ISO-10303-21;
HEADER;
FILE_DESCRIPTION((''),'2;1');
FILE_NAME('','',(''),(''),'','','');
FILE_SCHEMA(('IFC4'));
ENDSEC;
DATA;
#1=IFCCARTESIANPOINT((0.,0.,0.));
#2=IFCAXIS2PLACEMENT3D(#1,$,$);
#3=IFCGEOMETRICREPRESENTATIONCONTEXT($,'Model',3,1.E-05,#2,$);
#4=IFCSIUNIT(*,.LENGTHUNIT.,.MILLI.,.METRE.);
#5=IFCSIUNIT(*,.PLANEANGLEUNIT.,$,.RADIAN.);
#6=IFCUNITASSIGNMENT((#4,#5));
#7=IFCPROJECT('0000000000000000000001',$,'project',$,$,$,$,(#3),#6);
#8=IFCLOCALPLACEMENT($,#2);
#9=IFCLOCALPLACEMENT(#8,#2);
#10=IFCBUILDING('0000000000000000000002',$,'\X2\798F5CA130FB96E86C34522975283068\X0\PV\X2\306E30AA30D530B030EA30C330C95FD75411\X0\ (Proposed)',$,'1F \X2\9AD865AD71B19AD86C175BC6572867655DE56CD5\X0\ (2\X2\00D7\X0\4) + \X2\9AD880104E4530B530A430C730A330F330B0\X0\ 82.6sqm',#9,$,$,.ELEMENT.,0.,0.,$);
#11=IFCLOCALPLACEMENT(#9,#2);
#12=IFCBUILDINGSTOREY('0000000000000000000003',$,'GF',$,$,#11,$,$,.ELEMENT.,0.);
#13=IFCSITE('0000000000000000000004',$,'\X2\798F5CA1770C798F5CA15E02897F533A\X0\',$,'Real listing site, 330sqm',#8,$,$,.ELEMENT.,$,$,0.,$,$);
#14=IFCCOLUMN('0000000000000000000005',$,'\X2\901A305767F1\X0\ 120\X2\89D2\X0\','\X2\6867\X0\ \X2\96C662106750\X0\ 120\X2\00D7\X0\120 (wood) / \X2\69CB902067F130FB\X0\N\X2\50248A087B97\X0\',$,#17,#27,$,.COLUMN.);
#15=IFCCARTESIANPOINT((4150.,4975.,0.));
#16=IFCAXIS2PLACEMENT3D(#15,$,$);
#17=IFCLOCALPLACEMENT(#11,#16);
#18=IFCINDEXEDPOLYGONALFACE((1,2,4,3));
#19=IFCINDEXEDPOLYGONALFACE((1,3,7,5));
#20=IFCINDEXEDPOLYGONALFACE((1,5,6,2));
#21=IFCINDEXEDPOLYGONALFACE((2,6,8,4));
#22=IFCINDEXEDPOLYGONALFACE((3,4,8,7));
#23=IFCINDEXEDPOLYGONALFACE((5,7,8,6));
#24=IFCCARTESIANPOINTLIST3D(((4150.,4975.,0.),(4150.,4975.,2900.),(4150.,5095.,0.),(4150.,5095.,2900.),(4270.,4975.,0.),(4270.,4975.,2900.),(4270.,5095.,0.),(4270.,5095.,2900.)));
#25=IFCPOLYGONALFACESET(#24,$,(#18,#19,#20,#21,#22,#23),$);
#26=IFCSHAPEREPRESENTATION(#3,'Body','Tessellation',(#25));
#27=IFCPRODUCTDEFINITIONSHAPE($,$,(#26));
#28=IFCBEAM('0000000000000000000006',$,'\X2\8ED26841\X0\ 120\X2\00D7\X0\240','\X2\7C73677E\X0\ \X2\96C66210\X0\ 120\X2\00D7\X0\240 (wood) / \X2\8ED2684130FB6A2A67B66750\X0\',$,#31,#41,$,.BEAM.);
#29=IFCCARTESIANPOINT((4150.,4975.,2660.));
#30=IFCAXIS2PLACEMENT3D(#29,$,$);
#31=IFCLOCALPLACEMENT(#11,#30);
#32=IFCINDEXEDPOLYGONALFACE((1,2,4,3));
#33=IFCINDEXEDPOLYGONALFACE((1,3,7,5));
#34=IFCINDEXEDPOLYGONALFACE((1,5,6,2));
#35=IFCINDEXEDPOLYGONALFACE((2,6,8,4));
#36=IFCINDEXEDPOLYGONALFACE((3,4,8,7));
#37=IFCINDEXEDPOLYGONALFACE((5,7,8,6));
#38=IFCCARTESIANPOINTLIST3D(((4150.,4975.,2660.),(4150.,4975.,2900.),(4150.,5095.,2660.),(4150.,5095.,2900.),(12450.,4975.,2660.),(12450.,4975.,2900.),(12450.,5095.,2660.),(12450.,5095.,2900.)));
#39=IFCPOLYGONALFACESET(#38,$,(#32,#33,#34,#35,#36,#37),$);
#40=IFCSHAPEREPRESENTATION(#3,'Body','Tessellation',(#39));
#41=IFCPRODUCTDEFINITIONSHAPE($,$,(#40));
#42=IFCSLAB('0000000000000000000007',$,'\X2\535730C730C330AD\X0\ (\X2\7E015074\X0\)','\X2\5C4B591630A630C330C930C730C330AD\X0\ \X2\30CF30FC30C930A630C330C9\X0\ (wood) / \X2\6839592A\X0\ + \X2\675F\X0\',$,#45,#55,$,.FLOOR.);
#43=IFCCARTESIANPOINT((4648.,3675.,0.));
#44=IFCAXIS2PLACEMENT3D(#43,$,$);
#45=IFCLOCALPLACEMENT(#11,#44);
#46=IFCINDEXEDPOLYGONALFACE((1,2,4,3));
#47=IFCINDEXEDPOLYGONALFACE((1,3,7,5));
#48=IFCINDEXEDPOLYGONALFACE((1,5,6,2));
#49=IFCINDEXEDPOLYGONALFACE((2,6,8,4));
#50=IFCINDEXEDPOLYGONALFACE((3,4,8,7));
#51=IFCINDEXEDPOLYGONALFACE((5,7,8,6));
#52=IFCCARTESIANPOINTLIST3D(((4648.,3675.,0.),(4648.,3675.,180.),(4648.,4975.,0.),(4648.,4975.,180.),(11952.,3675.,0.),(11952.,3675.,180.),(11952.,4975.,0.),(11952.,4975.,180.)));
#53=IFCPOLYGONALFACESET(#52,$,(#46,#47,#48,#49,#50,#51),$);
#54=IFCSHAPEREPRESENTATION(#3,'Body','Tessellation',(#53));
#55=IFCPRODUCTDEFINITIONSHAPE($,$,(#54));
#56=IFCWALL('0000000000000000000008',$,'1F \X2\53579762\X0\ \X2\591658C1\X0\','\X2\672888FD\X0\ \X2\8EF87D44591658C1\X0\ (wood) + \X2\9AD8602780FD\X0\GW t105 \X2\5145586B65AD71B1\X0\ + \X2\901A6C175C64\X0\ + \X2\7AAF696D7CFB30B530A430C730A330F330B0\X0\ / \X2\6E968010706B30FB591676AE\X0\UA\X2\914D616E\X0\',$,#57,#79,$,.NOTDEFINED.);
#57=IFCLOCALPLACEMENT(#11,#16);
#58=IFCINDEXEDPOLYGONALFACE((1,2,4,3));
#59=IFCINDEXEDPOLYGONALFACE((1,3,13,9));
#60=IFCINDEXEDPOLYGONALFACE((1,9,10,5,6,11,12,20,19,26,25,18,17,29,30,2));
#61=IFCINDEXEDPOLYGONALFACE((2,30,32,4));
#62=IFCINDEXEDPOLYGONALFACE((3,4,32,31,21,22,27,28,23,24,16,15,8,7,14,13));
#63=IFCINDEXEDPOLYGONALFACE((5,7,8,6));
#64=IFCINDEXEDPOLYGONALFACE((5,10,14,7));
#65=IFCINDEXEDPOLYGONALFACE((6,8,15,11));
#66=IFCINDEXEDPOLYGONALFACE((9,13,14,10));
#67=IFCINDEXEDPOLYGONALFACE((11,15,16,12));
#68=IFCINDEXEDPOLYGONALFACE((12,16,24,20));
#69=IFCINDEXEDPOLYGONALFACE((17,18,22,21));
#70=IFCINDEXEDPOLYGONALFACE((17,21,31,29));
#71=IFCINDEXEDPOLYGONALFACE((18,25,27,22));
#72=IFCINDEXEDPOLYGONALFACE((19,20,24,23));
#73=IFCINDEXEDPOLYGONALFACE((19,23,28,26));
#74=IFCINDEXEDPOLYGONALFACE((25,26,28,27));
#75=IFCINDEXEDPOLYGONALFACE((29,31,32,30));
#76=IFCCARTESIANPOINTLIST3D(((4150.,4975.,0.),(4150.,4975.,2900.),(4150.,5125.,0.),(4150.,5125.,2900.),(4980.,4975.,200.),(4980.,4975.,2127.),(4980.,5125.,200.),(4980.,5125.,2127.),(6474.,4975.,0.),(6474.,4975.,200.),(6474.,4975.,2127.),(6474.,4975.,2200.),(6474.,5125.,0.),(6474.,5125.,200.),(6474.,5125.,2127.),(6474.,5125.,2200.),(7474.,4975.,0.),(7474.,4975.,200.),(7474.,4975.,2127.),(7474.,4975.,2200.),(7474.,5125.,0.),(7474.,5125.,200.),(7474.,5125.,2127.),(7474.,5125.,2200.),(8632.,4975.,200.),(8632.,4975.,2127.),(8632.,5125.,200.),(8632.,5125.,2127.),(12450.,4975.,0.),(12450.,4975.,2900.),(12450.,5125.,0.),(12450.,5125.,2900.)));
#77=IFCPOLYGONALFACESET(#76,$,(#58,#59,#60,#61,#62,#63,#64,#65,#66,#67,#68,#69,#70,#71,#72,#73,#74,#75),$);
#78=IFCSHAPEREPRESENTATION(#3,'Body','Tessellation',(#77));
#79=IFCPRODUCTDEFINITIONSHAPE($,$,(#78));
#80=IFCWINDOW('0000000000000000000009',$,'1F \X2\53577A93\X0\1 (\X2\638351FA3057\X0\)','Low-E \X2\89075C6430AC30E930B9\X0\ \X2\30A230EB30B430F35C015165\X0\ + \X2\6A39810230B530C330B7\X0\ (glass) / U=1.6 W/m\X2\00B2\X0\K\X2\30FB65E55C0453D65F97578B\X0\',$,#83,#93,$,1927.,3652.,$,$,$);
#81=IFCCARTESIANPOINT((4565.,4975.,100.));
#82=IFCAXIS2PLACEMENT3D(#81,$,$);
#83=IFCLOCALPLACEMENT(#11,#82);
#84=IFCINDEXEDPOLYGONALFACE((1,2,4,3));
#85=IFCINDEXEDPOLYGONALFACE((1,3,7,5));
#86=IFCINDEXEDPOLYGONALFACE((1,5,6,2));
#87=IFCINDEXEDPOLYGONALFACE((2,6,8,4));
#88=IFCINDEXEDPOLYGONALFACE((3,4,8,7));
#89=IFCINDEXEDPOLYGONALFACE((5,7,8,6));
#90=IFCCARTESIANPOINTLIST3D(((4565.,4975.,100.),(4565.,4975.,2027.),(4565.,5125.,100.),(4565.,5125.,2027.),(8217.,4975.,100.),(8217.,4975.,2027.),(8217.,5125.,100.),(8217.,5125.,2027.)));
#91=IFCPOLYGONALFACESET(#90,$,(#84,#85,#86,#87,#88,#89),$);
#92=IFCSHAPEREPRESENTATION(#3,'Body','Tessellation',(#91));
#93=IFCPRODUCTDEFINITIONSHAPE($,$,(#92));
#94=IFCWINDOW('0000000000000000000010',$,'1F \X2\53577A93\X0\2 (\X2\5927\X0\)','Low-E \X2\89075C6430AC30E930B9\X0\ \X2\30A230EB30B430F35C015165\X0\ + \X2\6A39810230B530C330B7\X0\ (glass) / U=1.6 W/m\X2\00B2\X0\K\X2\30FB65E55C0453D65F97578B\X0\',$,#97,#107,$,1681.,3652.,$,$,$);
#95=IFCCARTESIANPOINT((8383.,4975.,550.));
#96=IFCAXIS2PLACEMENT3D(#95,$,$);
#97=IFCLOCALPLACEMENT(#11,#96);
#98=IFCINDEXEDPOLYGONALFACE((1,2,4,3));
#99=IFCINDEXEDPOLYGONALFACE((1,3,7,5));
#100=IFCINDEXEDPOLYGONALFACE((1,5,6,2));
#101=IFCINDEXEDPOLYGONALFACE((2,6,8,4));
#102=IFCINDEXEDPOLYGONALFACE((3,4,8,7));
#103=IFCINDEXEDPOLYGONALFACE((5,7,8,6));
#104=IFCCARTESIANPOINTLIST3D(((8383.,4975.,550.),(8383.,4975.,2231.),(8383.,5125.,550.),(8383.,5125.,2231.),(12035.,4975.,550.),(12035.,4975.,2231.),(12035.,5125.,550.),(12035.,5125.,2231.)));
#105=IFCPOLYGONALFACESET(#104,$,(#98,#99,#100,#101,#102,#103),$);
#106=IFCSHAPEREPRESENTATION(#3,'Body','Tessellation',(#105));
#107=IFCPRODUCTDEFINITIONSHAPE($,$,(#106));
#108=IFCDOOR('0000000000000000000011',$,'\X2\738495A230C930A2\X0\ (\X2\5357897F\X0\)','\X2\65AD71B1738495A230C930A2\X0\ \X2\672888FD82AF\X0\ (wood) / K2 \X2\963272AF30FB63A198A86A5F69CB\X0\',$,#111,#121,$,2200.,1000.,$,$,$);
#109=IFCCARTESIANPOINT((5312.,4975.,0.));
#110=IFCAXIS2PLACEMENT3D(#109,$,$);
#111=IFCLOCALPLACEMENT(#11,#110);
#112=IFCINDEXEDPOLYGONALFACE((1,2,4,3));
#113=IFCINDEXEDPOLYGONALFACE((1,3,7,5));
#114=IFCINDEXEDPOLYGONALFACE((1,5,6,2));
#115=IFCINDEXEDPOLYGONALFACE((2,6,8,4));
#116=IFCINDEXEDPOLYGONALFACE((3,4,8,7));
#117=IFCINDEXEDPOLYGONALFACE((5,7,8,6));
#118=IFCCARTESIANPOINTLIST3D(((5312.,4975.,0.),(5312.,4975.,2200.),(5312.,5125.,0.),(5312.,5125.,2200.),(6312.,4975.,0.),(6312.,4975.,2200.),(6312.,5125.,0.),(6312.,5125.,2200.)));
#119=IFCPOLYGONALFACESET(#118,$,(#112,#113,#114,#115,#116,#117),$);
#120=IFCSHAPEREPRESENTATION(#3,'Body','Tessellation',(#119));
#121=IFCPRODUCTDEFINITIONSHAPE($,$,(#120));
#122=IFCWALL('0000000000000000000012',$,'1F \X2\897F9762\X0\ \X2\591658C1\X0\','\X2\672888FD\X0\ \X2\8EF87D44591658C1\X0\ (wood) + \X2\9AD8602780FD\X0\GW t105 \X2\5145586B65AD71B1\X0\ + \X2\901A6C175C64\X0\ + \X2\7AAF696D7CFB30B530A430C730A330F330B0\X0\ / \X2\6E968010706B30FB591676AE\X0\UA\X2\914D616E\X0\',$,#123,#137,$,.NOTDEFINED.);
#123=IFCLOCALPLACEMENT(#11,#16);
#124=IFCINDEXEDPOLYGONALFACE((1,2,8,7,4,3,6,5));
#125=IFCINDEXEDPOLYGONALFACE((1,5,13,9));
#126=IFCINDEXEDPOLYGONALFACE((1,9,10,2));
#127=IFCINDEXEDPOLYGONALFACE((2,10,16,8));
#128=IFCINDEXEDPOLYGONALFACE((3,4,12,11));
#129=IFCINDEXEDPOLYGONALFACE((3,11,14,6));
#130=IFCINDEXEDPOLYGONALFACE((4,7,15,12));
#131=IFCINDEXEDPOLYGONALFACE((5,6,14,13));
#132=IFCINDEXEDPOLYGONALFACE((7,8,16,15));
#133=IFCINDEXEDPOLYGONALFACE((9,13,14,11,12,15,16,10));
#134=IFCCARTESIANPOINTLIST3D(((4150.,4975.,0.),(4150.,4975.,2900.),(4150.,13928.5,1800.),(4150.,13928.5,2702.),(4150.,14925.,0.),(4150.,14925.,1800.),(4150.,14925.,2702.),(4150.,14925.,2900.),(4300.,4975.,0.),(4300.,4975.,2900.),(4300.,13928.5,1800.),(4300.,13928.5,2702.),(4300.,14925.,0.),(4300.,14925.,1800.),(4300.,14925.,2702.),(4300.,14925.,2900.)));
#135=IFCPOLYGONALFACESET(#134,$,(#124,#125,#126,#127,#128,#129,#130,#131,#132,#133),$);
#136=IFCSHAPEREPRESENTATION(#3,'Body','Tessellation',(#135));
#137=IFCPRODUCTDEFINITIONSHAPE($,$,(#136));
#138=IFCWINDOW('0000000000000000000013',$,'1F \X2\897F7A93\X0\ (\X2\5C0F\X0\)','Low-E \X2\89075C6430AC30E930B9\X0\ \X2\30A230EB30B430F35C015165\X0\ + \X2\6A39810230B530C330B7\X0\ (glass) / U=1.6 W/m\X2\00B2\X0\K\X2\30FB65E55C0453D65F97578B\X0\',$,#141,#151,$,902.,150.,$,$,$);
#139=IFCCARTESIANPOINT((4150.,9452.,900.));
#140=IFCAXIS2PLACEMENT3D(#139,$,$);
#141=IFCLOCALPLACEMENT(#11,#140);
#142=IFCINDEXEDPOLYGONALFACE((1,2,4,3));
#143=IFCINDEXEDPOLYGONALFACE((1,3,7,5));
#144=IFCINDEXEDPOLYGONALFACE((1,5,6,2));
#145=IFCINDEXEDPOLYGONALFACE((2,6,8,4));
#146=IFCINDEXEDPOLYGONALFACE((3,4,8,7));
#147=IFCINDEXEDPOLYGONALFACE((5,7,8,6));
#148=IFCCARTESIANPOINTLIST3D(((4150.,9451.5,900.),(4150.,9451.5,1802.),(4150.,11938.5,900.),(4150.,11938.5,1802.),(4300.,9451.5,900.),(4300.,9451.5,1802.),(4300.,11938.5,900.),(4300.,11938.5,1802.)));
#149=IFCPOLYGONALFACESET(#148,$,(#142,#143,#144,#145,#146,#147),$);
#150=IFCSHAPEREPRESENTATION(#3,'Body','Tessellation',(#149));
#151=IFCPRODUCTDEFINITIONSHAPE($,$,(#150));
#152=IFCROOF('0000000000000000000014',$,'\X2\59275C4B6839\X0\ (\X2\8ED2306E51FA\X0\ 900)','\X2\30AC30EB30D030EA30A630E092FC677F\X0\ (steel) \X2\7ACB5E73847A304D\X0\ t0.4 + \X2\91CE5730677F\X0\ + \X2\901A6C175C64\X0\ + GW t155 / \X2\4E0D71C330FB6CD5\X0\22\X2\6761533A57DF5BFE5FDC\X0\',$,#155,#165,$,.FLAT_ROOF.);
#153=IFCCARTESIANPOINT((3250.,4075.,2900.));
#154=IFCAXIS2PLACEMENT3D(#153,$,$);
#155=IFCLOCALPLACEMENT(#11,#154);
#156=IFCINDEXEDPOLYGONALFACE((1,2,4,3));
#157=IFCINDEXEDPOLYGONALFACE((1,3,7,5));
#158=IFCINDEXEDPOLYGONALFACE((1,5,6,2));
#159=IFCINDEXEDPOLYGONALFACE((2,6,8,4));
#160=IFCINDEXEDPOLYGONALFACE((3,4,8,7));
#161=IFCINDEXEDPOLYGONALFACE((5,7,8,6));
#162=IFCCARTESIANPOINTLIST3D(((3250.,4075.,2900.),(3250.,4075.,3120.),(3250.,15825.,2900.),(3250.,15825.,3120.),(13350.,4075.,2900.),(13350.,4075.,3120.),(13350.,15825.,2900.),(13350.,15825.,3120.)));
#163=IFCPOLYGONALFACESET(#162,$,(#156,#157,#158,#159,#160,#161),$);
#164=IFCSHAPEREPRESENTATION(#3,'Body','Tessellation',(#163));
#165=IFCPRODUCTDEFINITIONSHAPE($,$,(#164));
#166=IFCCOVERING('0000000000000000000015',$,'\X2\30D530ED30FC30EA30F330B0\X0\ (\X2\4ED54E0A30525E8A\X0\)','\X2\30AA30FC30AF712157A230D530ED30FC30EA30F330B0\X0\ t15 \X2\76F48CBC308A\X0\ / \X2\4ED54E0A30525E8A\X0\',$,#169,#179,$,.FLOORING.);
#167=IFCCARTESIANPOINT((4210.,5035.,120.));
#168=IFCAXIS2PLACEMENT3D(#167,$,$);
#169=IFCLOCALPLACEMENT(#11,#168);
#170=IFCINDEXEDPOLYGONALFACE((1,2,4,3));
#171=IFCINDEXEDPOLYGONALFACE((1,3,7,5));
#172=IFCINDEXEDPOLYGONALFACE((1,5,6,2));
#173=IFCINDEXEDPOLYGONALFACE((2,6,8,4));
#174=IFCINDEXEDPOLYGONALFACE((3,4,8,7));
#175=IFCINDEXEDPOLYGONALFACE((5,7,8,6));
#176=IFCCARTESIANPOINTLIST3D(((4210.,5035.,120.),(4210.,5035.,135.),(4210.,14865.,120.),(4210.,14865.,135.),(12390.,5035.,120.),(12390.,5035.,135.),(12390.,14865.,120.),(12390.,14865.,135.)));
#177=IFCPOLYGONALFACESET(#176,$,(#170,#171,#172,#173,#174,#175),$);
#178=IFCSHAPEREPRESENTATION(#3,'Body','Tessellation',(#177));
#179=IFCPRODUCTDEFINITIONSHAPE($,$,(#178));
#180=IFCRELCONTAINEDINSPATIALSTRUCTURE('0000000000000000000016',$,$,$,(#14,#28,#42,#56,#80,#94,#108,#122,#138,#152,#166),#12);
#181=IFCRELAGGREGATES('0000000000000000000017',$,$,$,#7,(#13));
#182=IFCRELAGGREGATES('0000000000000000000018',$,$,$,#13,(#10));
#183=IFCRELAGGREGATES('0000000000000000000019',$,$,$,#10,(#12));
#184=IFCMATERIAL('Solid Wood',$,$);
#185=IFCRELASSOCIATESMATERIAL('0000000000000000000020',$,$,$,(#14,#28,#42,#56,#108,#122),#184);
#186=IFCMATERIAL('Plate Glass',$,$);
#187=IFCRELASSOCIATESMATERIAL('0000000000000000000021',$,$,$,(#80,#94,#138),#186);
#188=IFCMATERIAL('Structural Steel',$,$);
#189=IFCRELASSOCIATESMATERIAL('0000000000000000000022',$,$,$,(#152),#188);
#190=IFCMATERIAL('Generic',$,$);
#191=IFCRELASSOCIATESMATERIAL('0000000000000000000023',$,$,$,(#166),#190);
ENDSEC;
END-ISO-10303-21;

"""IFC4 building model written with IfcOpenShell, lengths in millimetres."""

from ifc_helpers import new_model, si_unit, frame, frame_2d, origin, place, context, project, spatial, rectangle, extrude, material, element, fill, save


model = new_model("IFC4")

# Units and contexts
model_context = context("Model", 3, precision=1e-05, world=origin())
ifc_project = project(units=[si_unit("LENGTHUNIT", "METRE", prefix="MILLI"), si_unit("PLANEANGLEUNIT", "RADIAN")], contexts=[model_context])

# Site, building, storey
site_placement = place(None, origin())
site = spatial("IfcSite", under=ifc_project, at=site_placement, Name="福岡県福岡市西区", ObjectType="Real listing site, 330sqm", CompositionType="ELEMENT", RefElevation=0.0)
building_placement = place(site_placement, origin())
building = spatial("IfcBuilding", under=site, at=building_placement, Name="福岡・雨水利用とPVのオフグリッド志向 (Proposed)", ObjectType="1F 高断熱高気密在来工法 (2×4) + 高耐久サイディング 82.6sqm", CompositionType="ELEMENT", ElevationOfRefHeight=0.0, ElevationOfTerrain=0.0)
storey_placement = place(building_placement, origin())
storey = spatial("IfcBuildingStorey", under=building, at=storey_placement, Name="GF", CompositionType="ELEMENT", Elevation=0.0)

# Column
ifc_material_1 = material(Name="Solid Wood")
column_1_placement = place(storey_placement, frame((4150.0, 4975.0, 0.0)))
element("IfcColumn", 1, at=column_1_placement, inside=storey, material=ifc_material_1, Name="通し柱 120角", Description="桧 集成材 120×120 (wood) / 構造柱・N値計算", PredefinedType="COLUMN", context=model_context, shape_type="SweptSolid", body=[
    extrude(rectangle(XDim=120.0, YDim=120.0, at=frame_2d((60.0, 60.0))), frame((4150.0, 4975.0, 0.0)), (0.0, 0.0, 1.0), 2900.0),
])

# Beam
beam_1_placement = place(storey_placement, frame((4150.0, 4975.0, 2660.0)))
element("IfcBeam", 2, at=beam_1_placement, inside=storey, material=ifc_material_1, Name="軒桁 120×240", Description="米松 集成 120×240 (wood) / 軒桁・横架材", PredefinedType="BEAM", context=model_context, shape_type="SweptSolid", body=[
    extrude(rectangle(XDim=8300.0, YDim=120.0, at=frame_2d((4150.0, 60.0))), frame((4150.0, 4975.0, 2660.0)), (0.0, 0.0, 1.0), 240.0),
])

# Slab
slab_1_placement = place(storey_placement, frame((4648.0, 3675.0, 0.0)))
element("IfcSlab", 3, at=slab_1_placement, inside=storey, material=ifc_material_1, Name="南デッキ (縁側)", Description="屋外ウッドデッキ ハードウッド (wood) / 根太 + 束", PredefinedType="FLOOR", context=model_context, shape_type="SweptSolid", body=[
    extrude(rectangle(XDim=7304.0, YDim=1300.0, at=frame_2d((3652.0, 650.0))), frame((4648.0, 3675.0, 0.0)), (0.0, 0.0, 1.0), 180.0),
])

# Wall, openings, windows, door
wall_1_placement = place(storey_placement, frame((4150.0, 4975.0, 0.0)))
wall_1 = element("IfcWall", 4, at=wall_1_placement, inside=storey, material=ifc_material_1, Name="1F 南面 外壁", Description="木製 軸組外壁 (wood) + 高性能GW t105 充填断熱 + 通気層 + 窯業系サイディング / 準耐火・外皮UA配慮", PredefinedType="NOTDEFINED", context=model_context, shape_type="SweptSolid", body=[
    extrude(rectangle(XDim=8300.0, YDim=150.0, at=frame_2d((4150.0, 75.0))), frame((4150.0, 4975.0, 0.0)), (0.0, 0.0, 1.0), 2900.0),
])
opening_1_placement = place(storey_placement, frame((4565.0, 4975.0, 100.0)))
opening_1 = element("IfcOpeningElement", 5, at=opening_1_placement, cuts=wall_1, PredefinedType="NOTDEFINED", context=model_context, shape_type="SweptSolid", body=[
    extrude(rectangle(XDim=3652.0, YDim=150.0, at=frame_2d((1826.0, 75.0))), frame((4565.0, 4975.0, 100.0)), (0.0, 0.0, 1.0), 1927.0),
])
opening_2_placement = place(storey_placement, frame((8383.0, 4975.0, 550.0)))
opening_2 = element("IfcOpeningElement", 6, at=opening_2_placement, cuts=wall_1, PredefinedType="NOTDEFINED", context=model_context, shape_type="SweptSolid", body=[
    extrude(rectangle(XDim=3652.0, YDim=150.0, at=frame_2d((1826.0, 75.0))), frame((8383.0, 4975.0, 550.0)), (0.0, 0.0, 1.0), 1681.0),
])
opening_3_placement = place(storey_placement, frame((5312.0, 4975.0, 0.0)))
opening_3 = element("IfcOpeningElement", 7, at=opening_3_placement, cuts=wall_1, PredefinedType="NOTDEFINED", context=model_context, shape_type="SweptSolid", body=[
    extrude(rectangle(XDim=1000.0, YDim=150.0, at=frame_2d((500.0, 75.0))), frame((5312.0, 4975.0, 0.0)), (0.0, 0.0, 1.0), 2200.0),
])
ifc_material_2 = material(Name="Plate Glass")
window_1_placement = place(storey_placement, frame((4565.0, 4975.0, 100.0)))
window_1 = element("IfcWindow", 8, at=window_1_placement, inside=storey, material=ifc_material_2, Name="1F 南窓1 (掃出し)", Description="Low-E 複層ガラス アルゴン封入 + 樹脂サッシ (glass) / U=1.6 W/m²K・日射取得型", OverallHeight=1927.0, OverallWidth=3652.0, context=model_context, shape_type="SweptSolid", body=[
    extrude(rectangle(XDim=3652.0, YDim=150.0, at=frame_2d((1826.0, 75.0))), frame((4565.0, 4975.0, 100.0)), (0.0, 0.0, 1.0), 1927.0),
])
fill(opening_1, window_1)
window_2_placement = place(storey_placement, frame((8383.0, 4975.0, 550.0)))
window_2 = element("IfcWindow", 9, at=window_2_placement, inside=storey, material=ifc_material_2, Name="1F 南窓2 (大)", Description="Low-E 複層ガラス アルゴン封入 + 樹脂サッシ (glass) / U=1.6 W/m²K・日射取得型", OverallHeight=1681.0, OverallWidth=3652.0, context=model_context, shape_type="SweptSolid", body=[
    extrude(rectangle(XDim=3652.0, YDim=150.0, at=frame_2d((1826.0, 75.0))), frame((8383.0, 4975.0, 550.0)), (0.0, 0.0, 1.0), 1681.0),
])
fill(opening_2, window_2)
door_placement = place(storey_placement, frame((5312.0, 4975.0, 0.0)))
door = element("IfcDoor", 10, at=door_placement, inside=storey, material=ifc_material_1, Name="玄関ドア (南西)", Description="断熱玄関ドア 木製芯 (wood) / K2 防犯・採風機構", OverallHeight=2200.0, OverallWidth=1000.0, context=model_context, shape_type="SweptSolid", body=[
    extrude(rectangle(XDim=1000.0, YDim=150.0, at=frame_2d((500.0, 75.0))), frame((5312.0, 4975.0, 0.0)), (0.0, 0.0, 1.0), 2200.0),
])
fill(opening_3, door)

# Wall, opening, window
wall_2_placement = place(storey_placement, frame((4150.0, 4975.0, 0.0)))
wall_2 = element("IfcWall", 11, at=wall_2_placement, inside=storey, material=ifc_material_1, Name="1F 西面 外壁", Description="木製 軸組外壁 (wood) + 高性能GW t105 充填断熱 + 通気層 + 窯業系サイディング / 準耐火・外皮UA配慮", PredefinedType="NOTDEFINED", context=model_context, shape_type="SweptSolid", body=[
    extrude(rectangle(XDim=150.0, YDim=9950.0, at=frame_2d((75.0, 4975.0))), frame((4150.0, 4975.0, 0.0)), (0.0, 0.0, 1.0), 2900.0),
])
opening_4_placement = place(storey_placement, frame((4150.0, 9452.0, 900.0)))
opening_4 = element("IfcOpeningElement", 12, at=opening_4_placement, cuts=wall_2, PredefinedType="NOTDEFINED", context=model_context, shape_type="SweptSolid", body=[
    extrude(rectangle(XDim=150.0, YDim=2487.0, at=frame_2d((75.0, 1243.0))), frame((4150.0, 9452.0, 900.0)), (0.0, 0.0, 1.0), 902.0),
])
window_3_placement = place(storey_placement, frame((4150.0, 9452.0, 900.0)))
window_3 = element("IfcWindow", 13, at=window_3_placement, inside=storey, material=ifc_material_2, Name="1F 西窓 (小)", Description="Low-E 複層ガラス アルゴン封入 + 樹脂サッシ (glass) / U=1.6 W/m²K・日射取得型", OverallHeight=902.0, OverallWidth=150.0, context=model_context, shape_type="SweptSolid", body=[
    extrude(rectangle(XDim=150.0, YDim=2487.0, at=frame_2d((75.0, 1243.0))), frame((4150.0, 9452.0, 900.0)), (0.0, 0.0, 1.0), 902.0),
])
fill(opening_4, window_3)

# Roof
ifc_material_3 = material(Name="Structural Steel")
roof_placement = place(storey_placement, frame((3250.0, 4075.0, 2900.0)))
element("IfcRoof", 14, at=roof_placement, inside=storey, material=ifc_material_3, Name="大屋根 (軒の出 900)", Description="ガルバリウム鋼板 (steel) 立平葺き t0.4 + 野地板 + 通気層 + GW t155 / 不燃・法22条区域対応", PredefinedType="FLAT_ROOF", context=model_context, shape_type="SweptSolid", body=[
    extrude(rectangle(XDim=10100.0, YDim=11750.0, at=frame_2d((5050.0, 5875.0))), frame((3250.0, 4075.0, 2900.0)), (0.0, 0.0, 1.0), 220.0),
])

# Covering
ifc_material_4 = material(Name="Generic")
covering_1_placement = place(storey_placement, frame((4210.0, 5035.0, 120.0)))
element("IfcCovering", 15, at=covering_1_placement, inside=storey, material=ifc_material_4, Name="フローリング (仕上げ床)", Description="オーク無垢フローリング t15 直貼り / 仕上げ床", PredefinedType="FLOORING", context=model_context, shape_type="SweptSolid", body=[
    extrude(rectangle(XDim=8180.0, YDim=9830.0, at=frame_2d((4090.0, 4915.0))), frame((4210.0, 5035.0, 120.0)), (0.0, 0.0, 1.0), 15.0),
])

save(model, "model.ifc")
